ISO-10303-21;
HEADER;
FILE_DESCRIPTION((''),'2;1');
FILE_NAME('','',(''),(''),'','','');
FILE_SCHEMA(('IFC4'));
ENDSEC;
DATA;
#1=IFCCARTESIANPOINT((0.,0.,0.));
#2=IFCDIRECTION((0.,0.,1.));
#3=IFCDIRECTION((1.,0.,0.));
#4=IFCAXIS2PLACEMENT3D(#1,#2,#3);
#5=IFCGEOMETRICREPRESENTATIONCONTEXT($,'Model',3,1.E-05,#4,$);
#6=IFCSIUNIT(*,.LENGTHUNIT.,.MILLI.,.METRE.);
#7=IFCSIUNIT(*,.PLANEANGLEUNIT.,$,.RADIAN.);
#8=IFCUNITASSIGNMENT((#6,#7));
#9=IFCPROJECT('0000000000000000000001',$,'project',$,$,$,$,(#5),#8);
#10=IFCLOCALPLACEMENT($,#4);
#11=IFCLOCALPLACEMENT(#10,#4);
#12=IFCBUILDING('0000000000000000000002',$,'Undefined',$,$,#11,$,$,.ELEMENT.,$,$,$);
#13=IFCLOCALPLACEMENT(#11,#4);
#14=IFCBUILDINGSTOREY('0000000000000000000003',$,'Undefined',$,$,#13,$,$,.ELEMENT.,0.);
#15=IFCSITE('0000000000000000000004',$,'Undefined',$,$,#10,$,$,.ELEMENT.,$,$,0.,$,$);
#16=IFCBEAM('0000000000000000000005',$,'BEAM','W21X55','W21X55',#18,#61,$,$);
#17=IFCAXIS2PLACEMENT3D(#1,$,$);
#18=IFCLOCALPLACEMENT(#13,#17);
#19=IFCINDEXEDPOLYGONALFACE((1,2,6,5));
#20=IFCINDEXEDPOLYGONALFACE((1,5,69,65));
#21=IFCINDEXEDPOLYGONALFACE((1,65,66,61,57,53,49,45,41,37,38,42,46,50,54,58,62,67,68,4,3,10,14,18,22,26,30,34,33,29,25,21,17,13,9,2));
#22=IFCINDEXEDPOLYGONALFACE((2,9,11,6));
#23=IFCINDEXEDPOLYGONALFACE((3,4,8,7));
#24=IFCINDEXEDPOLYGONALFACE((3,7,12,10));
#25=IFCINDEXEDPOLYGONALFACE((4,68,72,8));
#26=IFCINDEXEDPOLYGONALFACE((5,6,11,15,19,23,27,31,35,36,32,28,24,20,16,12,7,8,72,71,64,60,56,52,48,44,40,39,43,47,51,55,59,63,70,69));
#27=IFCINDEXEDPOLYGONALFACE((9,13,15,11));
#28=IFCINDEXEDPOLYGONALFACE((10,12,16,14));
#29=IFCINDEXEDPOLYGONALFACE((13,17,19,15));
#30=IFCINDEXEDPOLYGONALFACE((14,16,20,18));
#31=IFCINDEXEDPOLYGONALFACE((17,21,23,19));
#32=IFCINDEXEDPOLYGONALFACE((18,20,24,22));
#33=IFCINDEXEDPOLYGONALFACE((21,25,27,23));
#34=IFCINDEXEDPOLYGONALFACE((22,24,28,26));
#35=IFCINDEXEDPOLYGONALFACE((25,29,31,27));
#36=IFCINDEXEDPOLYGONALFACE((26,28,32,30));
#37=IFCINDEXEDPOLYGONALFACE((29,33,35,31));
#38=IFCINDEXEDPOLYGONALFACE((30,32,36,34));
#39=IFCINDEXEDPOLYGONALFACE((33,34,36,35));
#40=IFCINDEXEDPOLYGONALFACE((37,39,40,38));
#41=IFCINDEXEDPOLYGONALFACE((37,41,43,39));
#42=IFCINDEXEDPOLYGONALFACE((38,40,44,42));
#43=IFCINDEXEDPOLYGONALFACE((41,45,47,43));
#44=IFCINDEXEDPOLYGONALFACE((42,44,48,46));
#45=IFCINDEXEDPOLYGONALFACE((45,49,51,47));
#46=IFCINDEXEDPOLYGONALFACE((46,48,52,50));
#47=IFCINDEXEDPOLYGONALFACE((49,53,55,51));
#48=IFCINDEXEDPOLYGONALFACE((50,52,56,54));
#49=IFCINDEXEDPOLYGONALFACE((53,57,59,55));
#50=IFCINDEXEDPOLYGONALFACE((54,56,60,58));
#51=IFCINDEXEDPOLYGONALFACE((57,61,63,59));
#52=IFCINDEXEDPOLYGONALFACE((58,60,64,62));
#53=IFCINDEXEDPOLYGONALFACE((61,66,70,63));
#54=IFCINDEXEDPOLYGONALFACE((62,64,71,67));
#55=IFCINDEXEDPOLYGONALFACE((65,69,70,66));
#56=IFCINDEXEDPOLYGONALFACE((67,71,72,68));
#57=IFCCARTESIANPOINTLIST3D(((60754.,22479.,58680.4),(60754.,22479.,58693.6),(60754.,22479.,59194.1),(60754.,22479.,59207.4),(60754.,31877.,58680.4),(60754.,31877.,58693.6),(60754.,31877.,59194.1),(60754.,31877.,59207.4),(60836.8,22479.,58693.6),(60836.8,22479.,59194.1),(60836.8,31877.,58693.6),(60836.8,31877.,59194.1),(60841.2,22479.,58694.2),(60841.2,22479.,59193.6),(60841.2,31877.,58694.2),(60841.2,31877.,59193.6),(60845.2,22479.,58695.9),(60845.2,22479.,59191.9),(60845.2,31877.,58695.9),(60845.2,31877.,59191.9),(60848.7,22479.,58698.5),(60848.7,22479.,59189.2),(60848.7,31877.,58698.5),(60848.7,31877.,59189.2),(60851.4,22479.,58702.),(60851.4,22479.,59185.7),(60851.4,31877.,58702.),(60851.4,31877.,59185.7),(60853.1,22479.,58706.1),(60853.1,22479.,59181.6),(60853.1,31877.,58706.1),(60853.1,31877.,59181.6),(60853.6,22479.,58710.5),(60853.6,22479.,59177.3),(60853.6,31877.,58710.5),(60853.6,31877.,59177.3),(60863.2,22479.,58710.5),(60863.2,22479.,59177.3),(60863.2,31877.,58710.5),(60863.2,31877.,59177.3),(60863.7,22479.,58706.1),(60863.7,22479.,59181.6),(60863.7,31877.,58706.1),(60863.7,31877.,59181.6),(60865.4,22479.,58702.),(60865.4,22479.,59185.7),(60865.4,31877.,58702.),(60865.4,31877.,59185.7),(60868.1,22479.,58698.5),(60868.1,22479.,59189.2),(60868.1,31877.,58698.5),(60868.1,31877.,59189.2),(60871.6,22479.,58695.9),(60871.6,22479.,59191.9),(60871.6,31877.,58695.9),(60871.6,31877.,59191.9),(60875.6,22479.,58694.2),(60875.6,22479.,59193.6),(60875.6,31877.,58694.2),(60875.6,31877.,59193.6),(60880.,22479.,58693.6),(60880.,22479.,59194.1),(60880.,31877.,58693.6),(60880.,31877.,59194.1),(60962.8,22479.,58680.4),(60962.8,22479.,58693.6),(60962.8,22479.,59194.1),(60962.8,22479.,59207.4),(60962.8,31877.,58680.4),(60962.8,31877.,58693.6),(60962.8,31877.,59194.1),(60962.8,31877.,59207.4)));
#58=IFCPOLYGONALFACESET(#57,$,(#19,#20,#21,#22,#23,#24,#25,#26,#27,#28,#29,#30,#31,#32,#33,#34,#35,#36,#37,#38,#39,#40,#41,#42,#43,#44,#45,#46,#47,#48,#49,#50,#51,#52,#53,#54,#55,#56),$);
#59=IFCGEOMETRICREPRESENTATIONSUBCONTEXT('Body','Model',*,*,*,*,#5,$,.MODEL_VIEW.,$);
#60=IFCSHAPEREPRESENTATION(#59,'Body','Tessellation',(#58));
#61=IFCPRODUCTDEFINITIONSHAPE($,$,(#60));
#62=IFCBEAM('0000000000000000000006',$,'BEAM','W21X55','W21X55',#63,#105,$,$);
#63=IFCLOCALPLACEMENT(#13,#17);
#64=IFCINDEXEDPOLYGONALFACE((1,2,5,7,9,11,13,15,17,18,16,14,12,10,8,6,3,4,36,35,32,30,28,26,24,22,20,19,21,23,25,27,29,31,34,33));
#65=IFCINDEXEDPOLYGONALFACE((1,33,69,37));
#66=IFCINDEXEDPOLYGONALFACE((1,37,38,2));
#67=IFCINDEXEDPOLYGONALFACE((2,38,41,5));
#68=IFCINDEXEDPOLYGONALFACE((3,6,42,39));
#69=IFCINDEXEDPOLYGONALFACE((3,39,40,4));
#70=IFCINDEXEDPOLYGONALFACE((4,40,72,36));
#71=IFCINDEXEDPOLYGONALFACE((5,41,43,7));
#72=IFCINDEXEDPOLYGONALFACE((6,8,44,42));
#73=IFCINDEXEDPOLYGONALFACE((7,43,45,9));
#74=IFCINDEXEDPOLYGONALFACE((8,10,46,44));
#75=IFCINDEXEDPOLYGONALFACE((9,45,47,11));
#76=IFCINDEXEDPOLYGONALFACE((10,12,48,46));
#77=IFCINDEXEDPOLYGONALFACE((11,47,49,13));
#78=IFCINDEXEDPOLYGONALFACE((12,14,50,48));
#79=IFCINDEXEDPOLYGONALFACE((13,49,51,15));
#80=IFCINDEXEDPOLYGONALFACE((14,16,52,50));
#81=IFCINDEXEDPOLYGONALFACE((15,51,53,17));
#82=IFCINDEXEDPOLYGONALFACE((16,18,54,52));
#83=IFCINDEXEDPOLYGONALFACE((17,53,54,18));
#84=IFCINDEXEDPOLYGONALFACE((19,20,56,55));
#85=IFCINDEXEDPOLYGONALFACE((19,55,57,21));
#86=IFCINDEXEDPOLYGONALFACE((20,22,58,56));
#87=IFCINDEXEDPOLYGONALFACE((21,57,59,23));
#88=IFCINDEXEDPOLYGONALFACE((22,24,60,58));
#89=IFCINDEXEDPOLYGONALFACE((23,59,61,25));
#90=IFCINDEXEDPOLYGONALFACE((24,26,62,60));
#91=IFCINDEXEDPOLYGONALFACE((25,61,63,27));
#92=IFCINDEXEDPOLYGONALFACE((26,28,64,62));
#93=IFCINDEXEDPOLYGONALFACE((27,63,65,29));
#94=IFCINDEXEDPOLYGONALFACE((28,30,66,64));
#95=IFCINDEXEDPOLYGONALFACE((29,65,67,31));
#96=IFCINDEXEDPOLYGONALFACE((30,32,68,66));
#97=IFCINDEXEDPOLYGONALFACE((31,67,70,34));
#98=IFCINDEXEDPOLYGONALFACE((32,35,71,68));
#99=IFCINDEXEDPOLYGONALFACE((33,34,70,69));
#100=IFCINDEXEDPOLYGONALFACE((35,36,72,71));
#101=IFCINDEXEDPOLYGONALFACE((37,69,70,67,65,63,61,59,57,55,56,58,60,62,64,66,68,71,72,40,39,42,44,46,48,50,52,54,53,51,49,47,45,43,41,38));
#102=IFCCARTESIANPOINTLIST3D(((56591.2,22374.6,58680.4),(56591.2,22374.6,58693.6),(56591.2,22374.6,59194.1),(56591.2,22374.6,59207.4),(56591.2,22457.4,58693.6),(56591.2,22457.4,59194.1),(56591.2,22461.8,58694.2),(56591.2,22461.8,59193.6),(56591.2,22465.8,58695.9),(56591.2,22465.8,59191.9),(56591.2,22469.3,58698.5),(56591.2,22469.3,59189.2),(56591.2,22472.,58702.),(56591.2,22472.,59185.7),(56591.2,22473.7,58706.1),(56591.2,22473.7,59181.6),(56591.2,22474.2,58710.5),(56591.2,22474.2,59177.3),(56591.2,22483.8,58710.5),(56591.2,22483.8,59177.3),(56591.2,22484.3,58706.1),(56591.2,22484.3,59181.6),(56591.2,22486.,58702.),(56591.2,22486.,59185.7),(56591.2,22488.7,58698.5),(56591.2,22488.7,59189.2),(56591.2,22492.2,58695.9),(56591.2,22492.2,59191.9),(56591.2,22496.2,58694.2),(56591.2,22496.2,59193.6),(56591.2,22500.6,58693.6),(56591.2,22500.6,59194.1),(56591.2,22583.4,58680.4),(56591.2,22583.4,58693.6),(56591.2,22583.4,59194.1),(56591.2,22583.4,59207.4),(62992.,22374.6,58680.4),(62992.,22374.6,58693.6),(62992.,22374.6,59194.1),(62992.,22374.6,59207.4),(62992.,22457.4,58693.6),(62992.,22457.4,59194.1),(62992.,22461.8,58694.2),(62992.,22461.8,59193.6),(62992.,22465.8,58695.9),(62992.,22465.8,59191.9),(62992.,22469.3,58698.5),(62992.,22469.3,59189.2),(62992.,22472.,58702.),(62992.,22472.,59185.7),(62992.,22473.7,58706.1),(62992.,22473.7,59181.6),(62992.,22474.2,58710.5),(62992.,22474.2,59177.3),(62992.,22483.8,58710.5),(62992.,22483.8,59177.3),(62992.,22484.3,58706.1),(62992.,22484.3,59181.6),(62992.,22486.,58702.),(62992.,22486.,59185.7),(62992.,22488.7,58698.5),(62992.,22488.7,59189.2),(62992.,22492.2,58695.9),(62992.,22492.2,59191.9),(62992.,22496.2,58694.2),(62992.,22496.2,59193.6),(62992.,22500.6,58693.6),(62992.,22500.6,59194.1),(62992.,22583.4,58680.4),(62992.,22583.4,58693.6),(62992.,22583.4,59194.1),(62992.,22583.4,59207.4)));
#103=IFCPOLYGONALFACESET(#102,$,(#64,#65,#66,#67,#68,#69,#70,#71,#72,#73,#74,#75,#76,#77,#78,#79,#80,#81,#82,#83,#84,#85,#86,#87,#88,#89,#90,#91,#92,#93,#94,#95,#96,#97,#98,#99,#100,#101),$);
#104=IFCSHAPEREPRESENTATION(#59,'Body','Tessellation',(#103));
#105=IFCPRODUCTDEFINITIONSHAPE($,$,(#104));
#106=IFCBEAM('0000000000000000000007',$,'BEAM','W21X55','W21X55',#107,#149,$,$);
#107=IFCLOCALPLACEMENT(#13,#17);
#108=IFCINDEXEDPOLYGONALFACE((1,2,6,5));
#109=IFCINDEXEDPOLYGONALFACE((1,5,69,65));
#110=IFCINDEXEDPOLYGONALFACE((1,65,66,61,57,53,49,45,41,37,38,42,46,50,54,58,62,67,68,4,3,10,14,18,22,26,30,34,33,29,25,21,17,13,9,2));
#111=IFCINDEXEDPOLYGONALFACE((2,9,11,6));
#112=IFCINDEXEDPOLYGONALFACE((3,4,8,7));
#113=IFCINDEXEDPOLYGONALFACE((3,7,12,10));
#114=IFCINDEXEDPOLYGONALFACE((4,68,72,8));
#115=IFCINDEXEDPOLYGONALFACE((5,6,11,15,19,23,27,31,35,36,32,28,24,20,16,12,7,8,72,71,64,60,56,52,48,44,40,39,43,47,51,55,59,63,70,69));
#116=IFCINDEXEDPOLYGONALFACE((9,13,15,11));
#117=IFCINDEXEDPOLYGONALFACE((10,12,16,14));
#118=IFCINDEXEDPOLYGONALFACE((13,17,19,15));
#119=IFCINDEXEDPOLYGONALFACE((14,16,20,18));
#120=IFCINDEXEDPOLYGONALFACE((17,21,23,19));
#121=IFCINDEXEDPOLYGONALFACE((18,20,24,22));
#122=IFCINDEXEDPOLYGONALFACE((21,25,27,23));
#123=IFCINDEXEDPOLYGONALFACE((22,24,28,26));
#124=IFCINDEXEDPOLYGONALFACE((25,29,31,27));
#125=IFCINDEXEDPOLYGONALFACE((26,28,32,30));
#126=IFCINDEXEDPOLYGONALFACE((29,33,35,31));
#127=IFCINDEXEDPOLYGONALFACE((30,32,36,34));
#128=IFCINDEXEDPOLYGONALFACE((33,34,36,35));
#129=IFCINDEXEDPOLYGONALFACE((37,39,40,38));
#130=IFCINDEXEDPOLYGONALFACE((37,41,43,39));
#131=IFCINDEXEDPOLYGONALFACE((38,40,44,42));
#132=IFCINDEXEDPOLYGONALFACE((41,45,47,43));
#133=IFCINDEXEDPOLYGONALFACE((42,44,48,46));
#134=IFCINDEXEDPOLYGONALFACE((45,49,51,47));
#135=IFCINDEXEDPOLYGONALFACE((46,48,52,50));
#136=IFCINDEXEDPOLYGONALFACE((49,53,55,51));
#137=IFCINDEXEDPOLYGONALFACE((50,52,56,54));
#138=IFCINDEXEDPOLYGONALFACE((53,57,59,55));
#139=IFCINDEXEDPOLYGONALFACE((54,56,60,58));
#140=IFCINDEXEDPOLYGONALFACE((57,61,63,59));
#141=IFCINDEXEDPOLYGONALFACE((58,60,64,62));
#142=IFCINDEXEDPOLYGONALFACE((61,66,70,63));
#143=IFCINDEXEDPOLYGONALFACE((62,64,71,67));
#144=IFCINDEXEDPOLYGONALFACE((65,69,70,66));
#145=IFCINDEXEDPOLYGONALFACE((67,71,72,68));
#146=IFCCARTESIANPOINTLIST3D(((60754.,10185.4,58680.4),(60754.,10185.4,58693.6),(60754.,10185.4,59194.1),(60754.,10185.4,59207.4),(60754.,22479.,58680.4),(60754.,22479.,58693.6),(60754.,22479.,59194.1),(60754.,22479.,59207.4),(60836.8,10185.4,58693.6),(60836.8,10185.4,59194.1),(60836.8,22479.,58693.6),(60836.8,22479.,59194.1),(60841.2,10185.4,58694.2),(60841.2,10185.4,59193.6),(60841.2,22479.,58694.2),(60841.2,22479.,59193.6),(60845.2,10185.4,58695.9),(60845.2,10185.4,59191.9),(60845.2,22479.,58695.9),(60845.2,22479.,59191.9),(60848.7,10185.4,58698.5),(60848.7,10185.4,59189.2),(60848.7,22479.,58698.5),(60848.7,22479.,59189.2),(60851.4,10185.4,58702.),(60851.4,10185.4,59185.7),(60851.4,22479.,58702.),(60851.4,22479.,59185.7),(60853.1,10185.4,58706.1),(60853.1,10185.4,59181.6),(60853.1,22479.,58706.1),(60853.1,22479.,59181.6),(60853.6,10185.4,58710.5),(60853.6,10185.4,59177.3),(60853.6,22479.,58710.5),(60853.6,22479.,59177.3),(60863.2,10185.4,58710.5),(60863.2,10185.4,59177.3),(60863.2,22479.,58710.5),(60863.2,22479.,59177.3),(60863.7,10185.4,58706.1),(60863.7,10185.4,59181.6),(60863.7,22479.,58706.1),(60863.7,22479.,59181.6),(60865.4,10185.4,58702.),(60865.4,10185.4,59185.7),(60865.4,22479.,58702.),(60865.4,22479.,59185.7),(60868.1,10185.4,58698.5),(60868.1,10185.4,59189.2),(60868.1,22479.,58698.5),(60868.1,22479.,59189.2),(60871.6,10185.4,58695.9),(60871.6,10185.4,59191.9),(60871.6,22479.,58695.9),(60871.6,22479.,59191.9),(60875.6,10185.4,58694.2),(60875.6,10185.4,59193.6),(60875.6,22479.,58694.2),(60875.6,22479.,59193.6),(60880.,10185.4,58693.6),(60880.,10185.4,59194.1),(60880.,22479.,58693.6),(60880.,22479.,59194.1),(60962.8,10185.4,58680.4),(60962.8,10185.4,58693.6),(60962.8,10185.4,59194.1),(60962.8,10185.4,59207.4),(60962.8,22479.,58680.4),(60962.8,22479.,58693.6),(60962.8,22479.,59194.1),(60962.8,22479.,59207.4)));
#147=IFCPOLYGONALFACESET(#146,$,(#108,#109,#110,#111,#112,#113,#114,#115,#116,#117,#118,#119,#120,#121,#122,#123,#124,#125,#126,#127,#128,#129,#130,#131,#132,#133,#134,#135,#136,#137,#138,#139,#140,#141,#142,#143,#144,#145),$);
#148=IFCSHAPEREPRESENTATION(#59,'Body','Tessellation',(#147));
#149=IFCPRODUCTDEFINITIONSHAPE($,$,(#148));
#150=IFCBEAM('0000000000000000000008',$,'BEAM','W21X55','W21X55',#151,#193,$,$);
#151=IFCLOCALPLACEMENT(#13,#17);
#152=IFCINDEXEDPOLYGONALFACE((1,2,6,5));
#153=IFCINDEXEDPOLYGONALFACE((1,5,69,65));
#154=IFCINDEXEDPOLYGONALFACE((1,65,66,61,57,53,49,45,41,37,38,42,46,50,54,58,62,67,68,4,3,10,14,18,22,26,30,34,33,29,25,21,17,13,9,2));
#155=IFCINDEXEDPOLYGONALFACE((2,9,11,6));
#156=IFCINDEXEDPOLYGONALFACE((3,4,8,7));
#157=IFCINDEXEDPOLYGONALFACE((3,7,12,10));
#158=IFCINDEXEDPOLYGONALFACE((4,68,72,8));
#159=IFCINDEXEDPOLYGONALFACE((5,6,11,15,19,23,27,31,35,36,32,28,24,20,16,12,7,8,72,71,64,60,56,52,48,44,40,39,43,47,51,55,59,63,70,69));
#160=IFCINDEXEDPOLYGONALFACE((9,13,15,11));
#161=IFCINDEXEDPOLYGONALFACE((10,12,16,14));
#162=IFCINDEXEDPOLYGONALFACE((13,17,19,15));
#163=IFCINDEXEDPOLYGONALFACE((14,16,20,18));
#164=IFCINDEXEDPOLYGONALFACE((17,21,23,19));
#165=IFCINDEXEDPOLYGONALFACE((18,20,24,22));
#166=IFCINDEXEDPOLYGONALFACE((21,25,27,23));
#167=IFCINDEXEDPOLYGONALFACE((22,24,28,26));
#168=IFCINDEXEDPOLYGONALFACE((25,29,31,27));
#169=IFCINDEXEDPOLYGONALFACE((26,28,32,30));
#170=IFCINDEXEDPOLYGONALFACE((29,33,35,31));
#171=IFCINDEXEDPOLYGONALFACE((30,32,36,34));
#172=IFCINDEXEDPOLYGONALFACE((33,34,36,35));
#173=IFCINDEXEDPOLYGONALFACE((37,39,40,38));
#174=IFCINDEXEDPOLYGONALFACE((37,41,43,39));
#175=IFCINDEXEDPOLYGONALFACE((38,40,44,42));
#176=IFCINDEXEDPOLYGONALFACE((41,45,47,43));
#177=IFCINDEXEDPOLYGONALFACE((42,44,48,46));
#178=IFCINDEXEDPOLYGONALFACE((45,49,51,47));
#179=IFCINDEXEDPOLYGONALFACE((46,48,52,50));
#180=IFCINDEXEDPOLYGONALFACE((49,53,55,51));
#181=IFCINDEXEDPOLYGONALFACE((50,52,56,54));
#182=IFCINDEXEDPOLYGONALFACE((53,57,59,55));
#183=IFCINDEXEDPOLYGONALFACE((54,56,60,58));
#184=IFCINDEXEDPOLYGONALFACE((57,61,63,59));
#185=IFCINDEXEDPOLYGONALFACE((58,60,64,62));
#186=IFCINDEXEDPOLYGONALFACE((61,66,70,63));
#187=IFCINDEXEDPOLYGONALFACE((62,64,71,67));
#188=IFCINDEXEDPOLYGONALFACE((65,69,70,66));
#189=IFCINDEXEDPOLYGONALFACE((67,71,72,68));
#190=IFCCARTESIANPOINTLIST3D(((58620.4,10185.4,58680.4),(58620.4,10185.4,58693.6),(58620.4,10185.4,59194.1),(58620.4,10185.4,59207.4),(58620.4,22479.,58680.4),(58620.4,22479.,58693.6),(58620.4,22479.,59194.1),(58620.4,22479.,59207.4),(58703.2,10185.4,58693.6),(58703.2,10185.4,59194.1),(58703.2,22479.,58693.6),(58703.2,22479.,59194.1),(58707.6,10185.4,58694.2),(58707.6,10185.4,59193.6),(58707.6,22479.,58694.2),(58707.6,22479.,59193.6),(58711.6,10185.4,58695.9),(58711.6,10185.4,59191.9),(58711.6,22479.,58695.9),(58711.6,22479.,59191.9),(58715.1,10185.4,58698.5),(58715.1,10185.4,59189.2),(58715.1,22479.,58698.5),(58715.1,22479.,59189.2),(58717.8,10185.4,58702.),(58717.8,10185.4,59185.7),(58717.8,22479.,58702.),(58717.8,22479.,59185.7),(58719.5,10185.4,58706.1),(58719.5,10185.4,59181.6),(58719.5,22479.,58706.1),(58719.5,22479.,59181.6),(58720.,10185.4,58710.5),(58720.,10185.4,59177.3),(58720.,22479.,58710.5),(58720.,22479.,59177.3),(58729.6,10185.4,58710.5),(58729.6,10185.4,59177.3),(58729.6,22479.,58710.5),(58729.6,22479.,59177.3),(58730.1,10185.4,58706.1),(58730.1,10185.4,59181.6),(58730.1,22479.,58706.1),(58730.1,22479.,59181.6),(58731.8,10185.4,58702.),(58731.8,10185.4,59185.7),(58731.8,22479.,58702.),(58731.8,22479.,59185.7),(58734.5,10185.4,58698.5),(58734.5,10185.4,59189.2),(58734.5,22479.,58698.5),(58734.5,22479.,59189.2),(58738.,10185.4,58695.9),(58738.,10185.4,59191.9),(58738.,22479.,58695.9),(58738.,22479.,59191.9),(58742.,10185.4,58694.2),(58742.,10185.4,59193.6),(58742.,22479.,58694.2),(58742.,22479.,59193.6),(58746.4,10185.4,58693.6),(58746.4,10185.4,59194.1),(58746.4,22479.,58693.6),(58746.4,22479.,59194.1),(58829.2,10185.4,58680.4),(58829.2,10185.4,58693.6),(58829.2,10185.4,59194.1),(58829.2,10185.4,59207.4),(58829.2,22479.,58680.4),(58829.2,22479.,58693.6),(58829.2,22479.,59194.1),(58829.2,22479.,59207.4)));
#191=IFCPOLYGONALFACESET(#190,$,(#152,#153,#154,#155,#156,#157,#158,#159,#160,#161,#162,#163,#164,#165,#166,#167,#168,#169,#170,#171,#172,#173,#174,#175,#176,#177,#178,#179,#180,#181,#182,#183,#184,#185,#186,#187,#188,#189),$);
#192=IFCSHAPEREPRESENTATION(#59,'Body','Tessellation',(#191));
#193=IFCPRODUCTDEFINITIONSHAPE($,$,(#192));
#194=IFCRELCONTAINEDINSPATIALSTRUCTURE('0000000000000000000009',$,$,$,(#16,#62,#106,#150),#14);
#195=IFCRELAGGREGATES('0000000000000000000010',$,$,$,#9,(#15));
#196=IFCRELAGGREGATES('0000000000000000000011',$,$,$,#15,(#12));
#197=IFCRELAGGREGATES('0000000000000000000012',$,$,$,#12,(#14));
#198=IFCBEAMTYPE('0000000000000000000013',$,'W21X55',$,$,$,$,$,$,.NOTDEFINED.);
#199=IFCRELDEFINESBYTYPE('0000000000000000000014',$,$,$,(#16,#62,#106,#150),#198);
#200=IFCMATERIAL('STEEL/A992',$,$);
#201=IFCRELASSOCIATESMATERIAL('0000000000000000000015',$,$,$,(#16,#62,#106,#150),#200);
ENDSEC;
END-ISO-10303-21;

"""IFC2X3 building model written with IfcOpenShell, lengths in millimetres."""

from ifc_helpers import new_model, si_unit, frame, origin_with_axes, origin_2d_with_axis, place, context, subcontext, project, spatial, i_section, extrude, material, type_object, element, save


model = new_model("IFC2X3")

# Units and contexts
model_context = context("Model", 3, precision=1e-05, world=origin_with_axes())
body_context = subcontext(model_context, "Body", "Model", "MODEL_VIEW")
ifc_project = project(units=[si_unit("LENGTHUNIT", "METRE", prefix="MILLI"), si_unit("PLANEANGLEUNIT", "RADIAN")], contexts=[model_context])

# Site, building, storey
site_placement = place(None, origin_with_axes())
site = spatial("IfcSite", under=ifc_project, at=site_placement, Name="Undefined", CompositionType="ELEMENT", RefElevation=0.0)
building_placement = place(site_placement, origin_with_axes())
building = spatial("IfcBuilding", under=site, at=building_placement, Name="Undefined", CompositionType="ELEMENT")
storey_placement = place(building_placement, origin_with_axes())
storey = spatial("IfcBuildingStorey", under=building, at=storey_placement, Name="Undefined", CompositionType="ELEMENT", Elevation=0.0)

# Shared definitions
ifc_material_1 = material(Name="STEEL/A992")

# Beams
beam_type_1 = type_object("IfcBeamType", Name="W21X55", PredefinedType="NOTDEFINED")
for number, where, z_axis, x_axis, name in (
    (1, (60858.4, 22479.0, 58943.9), (0.0, 0.0, 1.0), (0.0, 1.0, 0.0), "BEAM"),
):
    element("IfcBeam", number, at=place(storey_placement, frame(where, z_axis=z_axis, x_axis=x_axis)), inside=storey, type_object=beam_type_1, material=ifc_material_1, Name=name, Description="W21X55", ObjectType="W21X55", context=body_context, shape_type="SweptSolid", body=[
        extrude(i_section(OverallWidth=208.8, OverallDepth=527.0, WebThickness=9.5, FlangeThickness=13.3, FilletRadius=16.9, at=origin_2d_with_axis()), frame((9398.0, 0.0, 0.0), z_axis=(-1.0, 0.0, 0.0), x_axis=(0.0, -1.0, 0.0)), (0.0, 0.0, 1.0), 9398.0),
    ])
beam_1_placement = place(storey_placement, frame((56591.2, 22479.0, 58943.9), z_axis=(0.0, 0.0, 1.0), x_axis=(1.0, 0.0, 0.0)))
element("IfcBeam", 2, at=beam_1_placement, inside=storey, type_object=beam_type_1, material=ifc_material_1, Name="BEAM", Description="W21X55", ObjectType="W21X55", context=body_context, shape_type="SweptSolid", body=[
    extrude(i_section(OverallWidth=208.8, OverallDepth=527.0, WebThickness=9.5, FlangeThickness=13.3, FilletRadius=16.9, at=origin_2d_with_axis()), frame((6400.8, 0.0, 0.0), z_axis=(-1.0, 0.0, 0.0), x_axis=(0.0, -1.0, 0.0)), (0.0, 0.0, 1.0), 6400.8),
])
for number, where, z_axis, x_axis, name in (
    (3, (60858.4, 10185.4, 58943.9), (0.0, 0.0, 1.0), (0.0, 1.0, 0.0), "BEAM"),
    (4, (58724.8, 10185.4, 58943.9), (0.0, 0.0, 1.0), (0.0, 1.0, 0.0), "BEAM"),
):
    element("IfcBeam", number, at=place(storey_placement, frame(where, z_axis=z_axis, x_axis=x_axis)), inside=storey, type_object=beam_type_1, material=ifc_material_1, Name=name, Description="W21X55", ObjectType="W21X55", context=body_context, shape_type="SweptSolid", body=[
        extrude(i_section(OverallWidth=208.8, OverallDepth=527.0, WebThickness=9.5, FlangeThickness=13.3, FilletRadius=16.9, at=origin_2d_with_axis()), frame((12293.6, 0.0, 0.0), z_axis=(-1.0, 0.0, 0.0), x_axis=(0.0, -1.0, 0.0)), (0.0, 0.0, 1.0), 12293.6),
    ])

save(model, "model.ifc")
